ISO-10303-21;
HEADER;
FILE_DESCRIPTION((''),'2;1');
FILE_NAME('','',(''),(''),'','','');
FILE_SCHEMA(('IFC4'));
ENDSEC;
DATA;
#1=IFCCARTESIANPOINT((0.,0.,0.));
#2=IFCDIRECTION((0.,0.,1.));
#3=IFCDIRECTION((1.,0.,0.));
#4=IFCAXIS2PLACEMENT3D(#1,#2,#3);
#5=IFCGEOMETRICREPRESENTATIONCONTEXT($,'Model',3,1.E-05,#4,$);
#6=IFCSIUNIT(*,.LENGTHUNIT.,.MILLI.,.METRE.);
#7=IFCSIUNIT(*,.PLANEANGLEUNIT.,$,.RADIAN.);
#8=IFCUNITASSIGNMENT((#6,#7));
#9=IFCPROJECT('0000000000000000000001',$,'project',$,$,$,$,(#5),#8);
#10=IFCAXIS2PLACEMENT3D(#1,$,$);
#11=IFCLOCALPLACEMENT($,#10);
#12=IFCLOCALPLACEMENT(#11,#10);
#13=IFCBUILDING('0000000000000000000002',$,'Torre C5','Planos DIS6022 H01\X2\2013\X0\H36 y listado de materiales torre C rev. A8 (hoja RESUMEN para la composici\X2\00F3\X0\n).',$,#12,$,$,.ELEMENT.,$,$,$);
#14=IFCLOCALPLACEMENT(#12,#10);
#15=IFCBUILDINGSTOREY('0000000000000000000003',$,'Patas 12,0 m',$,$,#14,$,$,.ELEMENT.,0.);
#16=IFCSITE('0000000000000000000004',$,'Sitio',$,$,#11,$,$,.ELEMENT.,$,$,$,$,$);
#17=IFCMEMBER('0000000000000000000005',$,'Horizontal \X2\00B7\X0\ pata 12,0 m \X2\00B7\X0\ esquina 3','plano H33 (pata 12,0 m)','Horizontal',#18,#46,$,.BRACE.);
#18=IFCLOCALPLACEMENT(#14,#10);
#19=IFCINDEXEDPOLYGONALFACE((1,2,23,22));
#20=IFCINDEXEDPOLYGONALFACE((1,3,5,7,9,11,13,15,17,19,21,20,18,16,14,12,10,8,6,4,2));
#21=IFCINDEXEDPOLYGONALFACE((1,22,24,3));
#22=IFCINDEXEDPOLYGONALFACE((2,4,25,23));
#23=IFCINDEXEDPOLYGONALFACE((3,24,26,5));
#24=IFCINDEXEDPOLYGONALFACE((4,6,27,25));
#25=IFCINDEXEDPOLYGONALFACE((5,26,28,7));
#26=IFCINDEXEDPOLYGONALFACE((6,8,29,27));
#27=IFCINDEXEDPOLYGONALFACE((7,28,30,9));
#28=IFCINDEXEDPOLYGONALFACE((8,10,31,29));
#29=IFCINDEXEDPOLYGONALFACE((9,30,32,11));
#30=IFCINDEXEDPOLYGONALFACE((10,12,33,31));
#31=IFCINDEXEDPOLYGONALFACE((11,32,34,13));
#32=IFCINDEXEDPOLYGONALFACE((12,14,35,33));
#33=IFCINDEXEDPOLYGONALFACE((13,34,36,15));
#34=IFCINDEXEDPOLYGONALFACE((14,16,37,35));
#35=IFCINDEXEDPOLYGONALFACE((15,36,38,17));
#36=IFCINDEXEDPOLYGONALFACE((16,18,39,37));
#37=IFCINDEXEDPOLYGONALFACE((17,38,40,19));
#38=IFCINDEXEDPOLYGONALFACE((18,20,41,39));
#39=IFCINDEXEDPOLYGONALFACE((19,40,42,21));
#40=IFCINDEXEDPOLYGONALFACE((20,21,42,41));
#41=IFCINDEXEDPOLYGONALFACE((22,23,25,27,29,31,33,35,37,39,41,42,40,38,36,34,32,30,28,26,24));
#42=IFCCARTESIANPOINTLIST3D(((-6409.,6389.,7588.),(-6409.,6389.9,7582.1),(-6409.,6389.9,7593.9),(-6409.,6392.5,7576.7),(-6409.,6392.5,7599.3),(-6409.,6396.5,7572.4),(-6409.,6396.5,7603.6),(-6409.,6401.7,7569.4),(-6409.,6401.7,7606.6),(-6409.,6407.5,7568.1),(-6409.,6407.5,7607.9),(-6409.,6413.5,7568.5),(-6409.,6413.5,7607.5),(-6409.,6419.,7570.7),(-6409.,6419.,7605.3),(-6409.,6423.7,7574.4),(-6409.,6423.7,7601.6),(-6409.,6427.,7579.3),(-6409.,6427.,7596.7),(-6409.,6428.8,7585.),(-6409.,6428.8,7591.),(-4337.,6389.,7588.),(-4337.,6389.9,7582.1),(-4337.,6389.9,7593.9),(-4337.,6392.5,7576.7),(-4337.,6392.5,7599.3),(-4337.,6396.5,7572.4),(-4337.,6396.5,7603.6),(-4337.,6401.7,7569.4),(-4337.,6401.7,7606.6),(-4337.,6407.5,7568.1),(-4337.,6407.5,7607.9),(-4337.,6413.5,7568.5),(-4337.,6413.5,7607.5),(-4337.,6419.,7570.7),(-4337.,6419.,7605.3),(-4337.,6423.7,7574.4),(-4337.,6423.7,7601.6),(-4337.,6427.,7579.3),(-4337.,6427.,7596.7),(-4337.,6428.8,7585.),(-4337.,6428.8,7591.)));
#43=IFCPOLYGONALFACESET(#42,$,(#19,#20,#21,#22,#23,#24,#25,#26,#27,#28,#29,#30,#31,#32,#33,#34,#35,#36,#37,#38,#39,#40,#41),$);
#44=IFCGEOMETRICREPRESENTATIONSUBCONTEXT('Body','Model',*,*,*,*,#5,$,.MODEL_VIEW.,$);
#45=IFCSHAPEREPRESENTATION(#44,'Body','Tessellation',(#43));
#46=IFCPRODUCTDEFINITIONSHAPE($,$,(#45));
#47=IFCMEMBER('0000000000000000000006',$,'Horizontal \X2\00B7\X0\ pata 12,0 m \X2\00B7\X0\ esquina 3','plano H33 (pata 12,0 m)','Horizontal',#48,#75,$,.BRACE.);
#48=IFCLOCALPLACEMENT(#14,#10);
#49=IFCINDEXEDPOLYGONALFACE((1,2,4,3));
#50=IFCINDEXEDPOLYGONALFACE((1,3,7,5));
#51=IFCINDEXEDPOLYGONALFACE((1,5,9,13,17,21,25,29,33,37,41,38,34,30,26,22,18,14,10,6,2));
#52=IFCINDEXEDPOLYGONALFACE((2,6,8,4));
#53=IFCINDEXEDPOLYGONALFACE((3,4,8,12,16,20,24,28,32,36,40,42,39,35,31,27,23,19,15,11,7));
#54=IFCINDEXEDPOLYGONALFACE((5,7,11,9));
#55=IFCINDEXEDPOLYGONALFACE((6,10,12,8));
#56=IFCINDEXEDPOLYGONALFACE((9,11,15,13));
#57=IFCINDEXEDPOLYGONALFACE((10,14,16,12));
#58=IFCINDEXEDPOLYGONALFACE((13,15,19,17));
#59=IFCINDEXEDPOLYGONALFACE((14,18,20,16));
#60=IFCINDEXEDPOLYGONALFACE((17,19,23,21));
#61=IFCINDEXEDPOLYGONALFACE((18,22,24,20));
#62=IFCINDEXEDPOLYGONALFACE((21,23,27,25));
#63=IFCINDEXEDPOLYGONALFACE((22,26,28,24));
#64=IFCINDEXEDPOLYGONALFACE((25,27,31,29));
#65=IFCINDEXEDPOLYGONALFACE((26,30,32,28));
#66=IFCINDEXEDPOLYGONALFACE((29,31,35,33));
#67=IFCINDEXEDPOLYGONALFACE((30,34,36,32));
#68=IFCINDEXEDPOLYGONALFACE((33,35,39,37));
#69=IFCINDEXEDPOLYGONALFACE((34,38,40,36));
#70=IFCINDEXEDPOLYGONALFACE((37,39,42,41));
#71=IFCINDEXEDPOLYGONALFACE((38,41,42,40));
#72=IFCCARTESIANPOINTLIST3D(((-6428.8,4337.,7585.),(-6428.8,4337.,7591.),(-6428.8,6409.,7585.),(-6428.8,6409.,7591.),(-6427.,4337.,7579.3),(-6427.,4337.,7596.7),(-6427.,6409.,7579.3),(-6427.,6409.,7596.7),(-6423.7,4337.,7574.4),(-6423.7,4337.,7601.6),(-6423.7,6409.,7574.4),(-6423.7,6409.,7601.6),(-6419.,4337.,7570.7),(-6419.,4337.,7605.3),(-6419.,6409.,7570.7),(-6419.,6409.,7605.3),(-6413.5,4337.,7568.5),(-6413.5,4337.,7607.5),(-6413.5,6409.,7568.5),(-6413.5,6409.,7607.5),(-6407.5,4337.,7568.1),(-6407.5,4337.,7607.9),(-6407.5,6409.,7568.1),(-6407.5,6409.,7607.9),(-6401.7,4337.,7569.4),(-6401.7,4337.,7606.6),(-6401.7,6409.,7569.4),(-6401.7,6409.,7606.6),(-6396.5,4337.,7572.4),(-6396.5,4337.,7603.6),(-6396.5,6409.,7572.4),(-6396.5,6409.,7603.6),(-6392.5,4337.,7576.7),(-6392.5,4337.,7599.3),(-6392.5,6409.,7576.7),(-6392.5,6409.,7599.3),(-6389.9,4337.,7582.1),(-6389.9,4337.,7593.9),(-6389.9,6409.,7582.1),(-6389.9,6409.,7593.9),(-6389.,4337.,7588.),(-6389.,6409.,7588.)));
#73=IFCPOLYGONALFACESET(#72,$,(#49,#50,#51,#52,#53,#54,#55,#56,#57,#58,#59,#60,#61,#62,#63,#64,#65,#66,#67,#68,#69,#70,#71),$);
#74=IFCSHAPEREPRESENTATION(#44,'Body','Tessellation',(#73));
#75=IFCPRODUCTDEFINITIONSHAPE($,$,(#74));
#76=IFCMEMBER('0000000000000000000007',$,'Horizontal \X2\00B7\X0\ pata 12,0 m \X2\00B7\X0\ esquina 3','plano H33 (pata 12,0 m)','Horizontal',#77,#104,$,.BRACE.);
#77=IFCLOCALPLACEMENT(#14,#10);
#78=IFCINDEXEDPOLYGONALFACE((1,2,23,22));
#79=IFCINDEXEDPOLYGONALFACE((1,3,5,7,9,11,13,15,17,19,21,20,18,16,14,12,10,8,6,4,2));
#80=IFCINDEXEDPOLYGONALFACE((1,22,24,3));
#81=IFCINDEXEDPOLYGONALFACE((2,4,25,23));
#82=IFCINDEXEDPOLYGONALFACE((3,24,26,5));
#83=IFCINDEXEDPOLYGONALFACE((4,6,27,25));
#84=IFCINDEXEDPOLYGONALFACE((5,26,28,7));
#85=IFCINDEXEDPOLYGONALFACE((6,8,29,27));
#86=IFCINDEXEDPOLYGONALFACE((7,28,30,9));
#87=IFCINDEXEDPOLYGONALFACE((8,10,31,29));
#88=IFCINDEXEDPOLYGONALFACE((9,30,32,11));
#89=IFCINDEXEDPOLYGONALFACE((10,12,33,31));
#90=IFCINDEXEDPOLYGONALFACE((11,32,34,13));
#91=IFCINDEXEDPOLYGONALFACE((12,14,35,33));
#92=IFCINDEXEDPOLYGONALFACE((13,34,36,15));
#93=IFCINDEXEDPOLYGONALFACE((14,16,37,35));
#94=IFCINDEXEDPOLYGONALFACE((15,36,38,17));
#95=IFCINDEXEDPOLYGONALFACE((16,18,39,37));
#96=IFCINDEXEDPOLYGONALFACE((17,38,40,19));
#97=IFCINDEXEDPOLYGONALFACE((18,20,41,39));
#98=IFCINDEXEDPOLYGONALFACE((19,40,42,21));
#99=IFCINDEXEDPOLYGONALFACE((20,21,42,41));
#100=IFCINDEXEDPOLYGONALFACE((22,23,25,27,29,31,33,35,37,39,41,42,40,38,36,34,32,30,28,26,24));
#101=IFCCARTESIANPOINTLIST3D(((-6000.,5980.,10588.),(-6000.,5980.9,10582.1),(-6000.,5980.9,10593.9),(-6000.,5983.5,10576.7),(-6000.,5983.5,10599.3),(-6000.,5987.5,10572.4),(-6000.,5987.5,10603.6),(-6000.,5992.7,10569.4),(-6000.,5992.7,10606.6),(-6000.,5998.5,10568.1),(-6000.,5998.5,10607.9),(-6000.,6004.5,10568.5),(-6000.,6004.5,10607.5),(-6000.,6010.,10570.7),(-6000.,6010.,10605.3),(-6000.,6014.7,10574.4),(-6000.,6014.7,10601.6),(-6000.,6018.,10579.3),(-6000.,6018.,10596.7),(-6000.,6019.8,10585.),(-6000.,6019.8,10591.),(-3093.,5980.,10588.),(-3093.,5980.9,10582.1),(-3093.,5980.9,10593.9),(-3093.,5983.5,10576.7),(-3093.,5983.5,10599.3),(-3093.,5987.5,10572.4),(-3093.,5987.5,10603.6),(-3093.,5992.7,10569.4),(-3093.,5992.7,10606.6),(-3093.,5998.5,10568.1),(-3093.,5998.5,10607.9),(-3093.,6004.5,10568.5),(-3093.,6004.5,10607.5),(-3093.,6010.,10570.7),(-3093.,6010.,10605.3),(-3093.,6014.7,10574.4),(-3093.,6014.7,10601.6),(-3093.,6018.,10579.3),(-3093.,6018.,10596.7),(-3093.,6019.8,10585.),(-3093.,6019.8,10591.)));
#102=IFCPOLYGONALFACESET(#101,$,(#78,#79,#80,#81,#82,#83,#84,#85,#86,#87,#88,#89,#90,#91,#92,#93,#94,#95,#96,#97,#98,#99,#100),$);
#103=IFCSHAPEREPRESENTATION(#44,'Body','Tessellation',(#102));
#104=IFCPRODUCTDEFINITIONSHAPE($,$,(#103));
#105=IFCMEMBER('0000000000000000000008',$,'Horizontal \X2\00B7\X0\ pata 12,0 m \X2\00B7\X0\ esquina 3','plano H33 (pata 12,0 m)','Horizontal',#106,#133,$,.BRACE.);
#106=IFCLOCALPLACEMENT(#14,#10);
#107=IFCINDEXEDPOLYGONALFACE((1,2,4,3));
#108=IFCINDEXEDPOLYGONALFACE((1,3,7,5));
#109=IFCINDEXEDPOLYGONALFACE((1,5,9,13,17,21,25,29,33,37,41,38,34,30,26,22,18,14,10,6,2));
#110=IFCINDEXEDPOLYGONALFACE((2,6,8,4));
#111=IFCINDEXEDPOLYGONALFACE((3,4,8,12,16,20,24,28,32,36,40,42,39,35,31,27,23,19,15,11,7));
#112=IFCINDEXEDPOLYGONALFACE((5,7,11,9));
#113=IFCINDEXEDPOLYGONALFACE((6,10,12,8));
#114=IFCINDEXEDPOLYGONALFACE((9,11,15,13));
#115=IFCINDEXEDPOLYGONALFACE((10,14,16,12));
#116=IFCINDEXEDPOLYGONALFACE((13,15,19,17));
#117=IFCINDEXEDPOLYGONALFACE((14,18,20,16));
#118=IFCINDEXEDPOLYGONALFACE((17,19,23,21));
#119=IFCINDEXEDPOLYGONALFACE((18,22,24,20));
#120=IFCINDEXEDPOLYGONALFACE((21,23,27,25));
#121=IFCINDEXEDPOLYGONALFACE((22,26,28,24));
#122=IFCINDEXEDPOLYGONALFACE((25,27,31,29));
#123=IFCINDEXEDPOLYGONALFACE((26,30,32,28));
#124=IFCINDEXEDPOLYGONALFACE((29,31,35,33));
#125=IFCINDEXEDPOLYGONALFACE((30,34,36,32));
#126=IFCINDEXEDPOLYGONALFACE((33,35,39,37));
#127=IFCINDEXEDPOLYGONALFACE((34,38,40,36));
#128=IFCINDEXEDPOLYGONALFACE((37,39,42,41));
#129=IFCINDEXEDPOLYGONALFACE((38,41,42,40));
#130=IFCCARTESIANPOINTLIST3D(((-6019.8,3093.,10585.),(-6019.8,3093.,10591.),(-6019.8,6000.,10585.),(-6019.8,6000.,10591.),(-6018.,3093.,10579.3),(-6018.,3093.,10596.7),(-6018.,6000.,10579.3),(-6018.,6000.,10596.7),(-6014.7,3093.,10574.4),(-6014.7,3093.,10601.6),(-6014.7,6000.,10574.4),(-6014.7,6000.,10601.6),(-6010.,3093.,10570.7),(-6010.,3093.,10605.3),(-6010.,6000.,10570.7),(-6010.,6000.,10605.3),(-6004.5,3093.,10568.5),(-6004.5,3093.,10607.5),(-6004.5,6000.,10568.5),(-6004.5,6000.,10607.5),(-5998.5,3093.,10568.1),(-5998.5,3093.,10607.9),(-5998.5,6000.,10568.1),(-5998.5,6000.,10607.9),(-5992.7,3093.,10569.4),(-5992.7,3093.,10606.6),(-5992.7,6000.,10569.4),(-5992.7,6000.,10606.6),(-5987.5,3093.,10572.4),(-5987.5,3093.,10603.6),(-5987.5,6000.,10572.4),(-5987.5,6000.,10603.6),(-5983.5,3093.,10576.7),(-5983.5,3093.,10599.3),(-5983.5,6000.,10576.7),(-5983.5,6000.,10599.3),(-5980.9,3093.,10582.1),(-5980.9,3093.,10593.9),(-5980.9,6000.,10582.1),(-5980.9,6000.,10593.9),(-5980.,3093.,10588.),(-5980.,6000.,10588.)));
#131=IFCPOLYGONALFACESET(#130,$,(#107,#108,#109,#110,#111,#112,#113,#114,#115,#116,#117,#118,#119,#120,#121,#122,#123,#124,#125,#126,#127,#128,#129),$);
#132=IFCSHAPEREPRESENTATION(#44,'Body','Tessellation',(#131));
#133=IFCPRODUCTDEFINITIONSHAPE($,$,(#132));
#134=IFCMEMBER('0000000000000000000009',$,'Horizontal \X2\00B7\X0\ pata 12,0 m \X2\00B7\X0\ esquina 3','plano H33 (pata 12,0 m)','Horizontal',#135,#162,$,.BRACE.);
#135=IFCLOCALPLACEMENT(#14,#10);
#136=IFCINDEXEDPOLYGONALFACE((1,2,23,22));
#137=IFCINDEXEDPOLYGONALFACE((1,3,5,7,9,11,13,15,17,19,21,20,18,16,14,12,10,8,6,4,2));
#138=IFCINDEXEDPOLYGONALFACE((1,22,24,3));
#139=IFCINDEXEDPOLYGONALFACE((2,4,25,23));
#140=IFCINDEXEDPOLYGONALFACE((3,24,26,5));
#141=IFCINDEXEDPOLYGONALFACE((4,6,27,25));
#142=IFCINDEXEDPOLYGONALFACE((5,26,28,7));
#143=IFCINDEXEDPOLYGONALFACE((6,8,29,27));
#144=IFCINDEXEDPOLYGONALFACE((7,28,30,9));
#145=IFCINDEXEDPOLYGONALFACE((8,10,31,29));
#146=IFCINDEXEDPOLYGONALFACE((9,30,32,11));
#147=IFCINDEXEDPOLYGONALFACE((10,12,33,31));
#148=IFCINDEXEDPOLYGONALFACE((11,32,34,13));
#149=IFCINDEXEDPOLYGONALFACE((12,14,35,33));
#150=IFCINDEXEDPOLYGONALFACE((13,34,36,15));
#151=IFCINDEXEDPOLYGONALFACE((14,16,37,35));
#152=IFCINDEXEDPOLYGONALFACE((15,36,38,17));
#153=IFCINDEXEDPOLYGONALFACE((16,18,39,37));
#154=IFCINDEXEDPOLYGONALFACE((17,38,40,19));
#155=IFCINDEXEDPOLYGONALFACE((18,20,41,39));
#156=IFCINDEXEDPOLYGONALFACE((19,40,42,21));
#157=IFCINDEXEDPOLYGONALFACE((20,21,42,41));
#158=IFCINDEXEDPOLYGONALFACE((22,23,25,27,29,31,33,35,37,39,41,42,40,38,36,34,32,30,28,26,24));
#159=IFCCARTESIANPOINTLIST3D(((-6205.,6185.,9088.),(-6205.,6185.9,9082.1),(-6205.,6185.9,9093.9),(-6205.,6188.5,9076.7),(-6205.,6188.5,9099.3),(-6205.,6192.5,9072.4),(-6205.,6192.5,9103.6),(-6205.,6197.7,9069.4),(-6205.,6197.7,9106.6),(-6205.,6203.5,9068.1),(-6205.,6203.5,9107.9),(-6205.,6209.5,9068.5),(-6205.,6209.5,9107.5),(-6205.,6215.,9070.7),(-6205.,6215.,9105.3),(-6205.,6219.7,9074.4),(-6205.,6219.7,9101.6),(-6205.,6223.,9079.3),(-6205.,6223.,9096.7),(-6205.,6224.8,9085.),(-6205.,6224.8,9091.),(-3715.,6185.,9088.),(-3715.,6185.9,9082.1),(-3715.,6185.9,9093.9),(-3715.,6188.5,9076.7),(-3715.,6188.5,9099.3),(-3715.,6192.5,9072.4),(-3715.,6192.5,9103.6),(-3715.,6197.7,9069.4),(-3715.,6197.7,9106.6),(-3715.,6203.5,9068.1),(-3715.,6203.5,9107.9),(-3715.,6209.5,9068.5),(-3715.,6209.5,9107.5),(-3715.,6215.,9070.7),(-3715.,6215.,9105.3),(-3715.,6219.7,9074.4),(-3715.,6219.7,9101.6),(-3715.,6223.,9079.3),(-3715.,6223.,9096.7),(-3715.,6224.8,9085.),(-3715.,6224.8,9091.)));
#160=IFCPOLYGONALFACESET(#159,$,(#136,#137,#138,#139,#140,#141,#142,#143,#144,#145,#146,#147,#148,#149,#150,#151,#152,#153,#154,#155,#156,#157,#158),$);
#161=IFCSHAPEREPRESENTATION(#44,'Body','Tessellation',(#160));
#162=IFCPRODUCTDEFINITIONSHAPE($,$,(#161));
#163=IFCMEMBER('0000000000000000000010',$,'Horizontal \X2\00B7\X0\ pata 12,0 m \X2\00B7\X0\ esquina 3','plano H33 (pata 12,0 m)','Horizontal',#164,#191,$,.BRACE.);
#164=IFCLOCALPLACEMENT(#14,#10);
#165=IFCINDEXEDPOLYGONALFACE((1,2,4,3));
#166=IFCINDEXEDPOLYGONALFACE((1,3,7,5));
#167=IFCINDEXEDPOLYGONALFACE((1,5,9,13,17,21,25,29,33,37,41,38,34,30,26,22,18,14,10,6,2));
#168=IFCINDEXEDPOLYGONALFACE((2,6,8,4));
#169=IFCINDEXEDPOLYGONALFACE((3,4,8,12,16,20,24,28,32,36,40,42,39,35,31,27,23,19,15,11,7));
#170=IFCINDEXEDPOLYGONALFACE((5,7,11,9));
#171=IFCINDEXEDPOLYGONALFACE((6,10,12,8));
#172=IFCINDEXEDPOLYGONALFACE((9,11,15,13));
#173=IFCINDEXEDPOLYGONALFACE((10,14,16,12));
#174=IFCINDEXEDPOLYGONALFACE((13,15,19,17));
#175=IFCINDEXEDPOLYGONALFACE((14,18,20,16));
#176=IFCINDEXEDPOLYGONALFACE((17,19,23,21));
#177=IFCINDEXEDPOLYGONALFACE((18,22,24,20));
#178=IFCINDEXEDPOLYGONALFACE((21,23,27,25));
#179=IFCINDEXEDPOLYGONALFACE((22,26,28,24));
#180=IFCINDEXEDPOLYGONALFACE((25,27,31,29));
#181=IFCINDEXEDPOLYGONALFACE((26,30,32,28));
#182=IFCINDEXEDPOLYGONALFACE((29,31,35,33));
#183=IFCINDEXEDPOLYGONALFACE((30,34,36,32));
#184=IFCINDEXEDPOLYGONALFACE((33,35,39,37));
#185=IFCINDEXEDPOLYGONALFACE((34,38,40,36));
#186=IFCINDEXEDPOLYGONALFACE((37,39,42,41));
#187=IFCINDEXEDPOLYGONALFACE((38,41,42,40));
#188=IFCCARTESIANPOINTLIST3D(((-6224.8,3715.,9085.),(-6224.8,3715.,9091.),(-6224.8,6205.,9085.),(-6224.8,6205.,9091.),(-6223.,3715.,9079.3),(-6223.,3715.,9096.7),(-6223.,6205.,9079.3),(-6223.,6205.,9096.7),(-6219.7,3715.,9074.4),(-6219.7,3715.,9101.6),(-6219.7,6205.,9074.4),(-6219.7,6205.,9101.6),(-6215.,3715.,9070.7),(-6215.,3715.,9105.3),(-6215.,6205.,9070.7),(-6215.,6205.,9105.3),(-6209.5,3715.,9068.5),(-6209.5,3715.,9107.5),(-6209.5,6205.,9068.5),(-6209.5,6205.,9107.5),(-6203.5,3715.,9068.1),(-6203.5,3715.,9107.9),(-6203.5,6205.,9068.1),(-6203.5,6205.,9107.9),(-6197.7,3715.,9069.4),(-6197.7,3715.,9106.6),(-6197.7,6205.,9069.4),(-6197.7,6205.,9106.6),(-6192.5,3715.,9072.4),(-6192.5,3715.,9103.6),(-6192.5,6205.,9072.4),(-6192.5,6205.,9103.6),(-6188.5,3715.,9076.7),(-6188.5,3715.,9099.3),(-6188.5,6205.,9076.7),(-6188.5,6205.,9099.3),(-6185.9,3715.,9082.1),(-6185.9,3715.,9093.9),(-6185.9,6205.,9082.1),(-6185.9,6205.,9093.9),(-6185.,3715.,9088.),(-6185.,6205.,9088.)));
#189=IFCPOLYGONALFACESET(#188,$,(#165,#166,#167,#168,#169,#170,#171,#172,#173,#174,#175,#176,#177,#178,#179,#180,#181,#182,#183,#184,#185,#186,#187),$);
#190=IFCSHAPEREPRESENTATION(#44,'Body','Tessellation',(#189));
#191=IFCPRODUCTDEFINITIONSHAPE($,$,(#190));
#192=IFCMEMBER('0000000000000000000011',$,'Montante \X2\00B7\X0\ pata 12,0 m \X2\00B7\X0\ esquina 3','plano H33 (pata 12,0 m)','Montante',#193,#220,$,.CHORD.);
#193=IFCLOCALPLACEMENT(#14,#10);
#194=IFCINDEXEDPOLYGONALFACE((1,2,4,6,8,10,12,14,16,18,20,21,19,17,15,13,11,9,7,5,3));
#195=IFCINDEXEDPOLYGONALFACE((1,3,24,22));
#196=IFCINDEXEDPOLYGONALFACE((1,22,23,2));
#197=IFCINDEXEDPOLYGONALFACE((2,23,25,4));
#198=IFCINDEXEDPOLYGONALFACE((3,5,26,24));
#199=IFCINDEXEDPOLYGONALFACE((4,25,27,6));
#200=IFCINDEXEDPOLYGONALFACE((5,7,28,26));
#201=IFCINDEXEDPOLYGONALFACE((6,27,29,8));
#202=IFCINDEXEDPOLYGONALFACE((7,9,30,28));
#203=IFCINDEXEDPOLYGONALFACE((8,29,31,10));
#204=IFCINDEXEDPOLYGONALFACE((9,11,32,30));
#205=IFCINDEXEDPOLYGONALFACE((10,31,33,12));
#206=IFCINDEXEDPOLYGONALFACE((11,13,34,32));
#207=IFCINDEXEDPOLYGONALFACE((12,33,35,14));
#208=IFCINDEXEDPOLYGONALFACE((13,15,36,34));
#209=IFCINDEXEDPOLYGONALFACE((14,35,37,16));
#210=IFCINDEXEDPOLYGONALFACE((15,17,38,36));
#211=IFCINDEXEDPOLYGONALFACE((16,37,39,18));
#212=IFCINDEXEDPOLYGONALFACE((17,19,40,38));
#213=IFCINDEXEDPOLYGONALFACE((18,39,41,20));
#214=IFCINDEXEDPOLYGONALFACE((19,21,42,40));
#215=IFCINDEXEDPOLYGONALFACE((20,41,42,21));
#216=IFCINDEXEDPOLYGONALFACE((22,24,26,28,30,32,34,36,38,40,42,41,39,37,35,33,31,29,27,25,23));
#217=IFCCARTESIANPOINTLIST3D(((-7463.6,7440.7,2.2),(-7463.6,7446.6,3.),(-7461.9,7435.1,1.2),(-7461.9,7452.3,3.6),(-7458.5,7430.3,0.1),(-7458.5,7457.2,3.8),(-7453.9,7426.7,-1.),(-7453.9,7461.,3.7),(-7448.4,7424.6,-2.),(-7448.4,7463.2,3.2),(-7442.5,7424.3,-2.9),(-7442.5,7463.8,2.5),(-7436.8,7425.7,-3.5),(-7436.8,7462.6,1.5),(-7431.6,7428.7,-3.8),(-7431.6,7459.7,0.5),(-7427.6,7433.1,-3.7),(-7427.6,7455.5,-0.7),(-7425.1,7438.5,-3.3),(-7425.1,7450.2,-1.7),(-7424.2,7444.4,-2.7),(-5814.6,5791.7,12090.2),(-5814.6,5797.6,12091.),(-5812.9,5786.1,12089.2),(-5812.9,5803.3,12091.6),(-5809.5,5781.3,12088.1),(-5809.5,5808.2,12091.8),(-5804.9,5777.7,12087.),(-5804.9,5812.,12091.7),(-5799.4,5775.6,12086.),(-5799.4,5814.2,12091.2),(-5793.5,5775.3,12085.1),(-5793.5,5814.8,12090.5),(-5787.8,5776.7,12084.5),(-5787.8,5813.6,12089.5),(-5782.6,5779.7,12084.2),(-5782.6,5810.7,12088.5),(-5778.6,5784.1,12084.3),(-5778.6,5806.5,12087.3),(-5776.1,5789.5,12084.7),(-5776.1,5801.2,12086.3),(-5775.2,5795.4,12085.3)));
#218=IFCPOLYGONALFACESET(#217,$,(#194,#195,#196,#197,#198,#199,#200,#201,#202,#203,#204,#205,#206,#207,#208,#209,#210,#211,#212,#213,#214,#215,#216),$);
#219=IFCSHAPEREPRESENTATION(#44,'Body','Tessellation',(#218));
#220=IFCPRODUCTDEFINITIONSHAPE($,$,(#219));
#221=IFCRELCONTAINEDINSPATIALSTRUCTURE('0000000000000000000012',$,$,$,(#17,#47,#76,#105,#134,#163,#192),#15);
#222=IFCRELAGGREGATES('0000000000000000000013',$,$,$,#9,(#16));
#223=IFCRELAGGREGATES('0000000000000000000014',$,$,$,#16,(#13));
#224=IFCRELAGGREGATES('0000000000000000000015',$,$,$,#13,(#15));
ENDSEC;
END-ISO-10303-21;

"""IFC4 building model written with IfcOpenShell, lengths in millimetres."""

from ifc_helpers import new_model, si_unit, frame, origin, origin_with_axes, place, context, subcontext, project, spatial, circle, extrude, element, save


model = new_model("IFC4")

# Units and contexts
model_context = context("Model", 3, precision=1e-05, world=origin_with_axes())
body_context = subcontext(model_context, "Body", "Model", "MODEL_VIEW")
ifc_project = project(units=[si_unit("LENGTHUNIT", "METRE", prefix="MILLI"), si_unit("PLANEANGLEUNIT", "RADIAN")], contexts=[model_context])

# Site, building, storey
site_placement = place(None, origin())
site = spatial("IfcSite", under=ifc_project, at=site_placement, Name="Sitio", CompositionType="ELEMENT")
building_placement = place(site_placement, origin())
building = spatial("IfcBuilding", under=site, at=building_placement, Name="Torre C5", Description="Planos DIS6022 H01–H36 y listado de materiales torre C rev. A8 (hoja RESUMEN para la composición).", CompositionType="ELEMENT")
storey_placement = place(building_placement, origin())
storey = spatial("IfcBuildingStorey", under=building, at=storey_placement, Name="Patas 12,0 m", CompositionType="ELEMENT", Elevation=0.0)

# Members
for number, where, z_axis, x_axis, name in (
    (1, (-4337.0, 6409.0, 7588.0), (-1.0, 0.0, 0.0), (0.0, -1.0, 0.0), "Horizontal · pata 12,0 m · esquina 3"),
    (2, (-6409.0, 4337.0, 7588.0), (0.0, 1.0, 0.0), (1.0, 0.0, 0.0), "Horizontal · pata 12,0 m · esquina 3"),
):
    element("IfcMember", number, at=place(storey_placement, frame(where, z_axis=z_axis, x_axis=x_axis)), inside=storey, Name=name, Description="plano H33 (pata 12,0 m)", ObjectType="Horizontal", PredefinedType="BRACE", context=body_context, shape_type="SweptSolid", body=[
        extrude(circle(Radius=20.0), None, (0.0, 0.0, 1.0), 2072.0),
    ])
for number, where, z_axis, x_axis, name in (
    (3, (-6000.0, 6000.0, 10588.0), (1.0, 0.0, 0.0), (0.0, -1.0, 0.0), "Horizontal · pata 12,0 m · esquina 3"),
    (4, (-6000.0, 6000.0, 10588.0), (0.0, -1.0, 0.0), (1.0, 0.0, 0.0), "Horizontal · pata 12,0 m · esquina 3"),
):
    element("IfcMember", number, at=place(storey_placement, frame(where, z_axis=z_axis, x_axis=x_axis)), inside=storey, Name=name, Description="plano H33 (pata 12,0 m)", ObjectType="Horizontal", PredefinedType="BRACE", context=body_context, shape_type="SweptSolid", body=[
        extrude(circle(Radius=20.0), None, (0.0, 0.0, 1.0), 2907.0),
    ])
for number, where, z_axis, x_axis, name in (
    (5, (-6205.0, 6205.0, 9088.0), (1.0, 0.0, 0.0), (0.0, -1.0, 0.0), "Horizontal · pata 12,0 m · esquina 3"),
    (6, (-6205.0, 6205.0, 9088.0), (0.0, -1.0, 0.0), (1.0, 0.0, 0.0), "Horizontal · pata 12,0 m · esquina 3"),
):
    element("IfcMember", number, at=place(storey_placement, frame(where, z_axis=z_axis, x_axis=x_axis)), inside=storey, Name=name, Description="plano H33 (pata 12,0 m)", ObjectType="Horizontal", PredefinedType="BRACE", context=body_context, shape_type="SweptSolid", body=[
        extrude(circle(Radius=20.0), None, (0.0, 0.0, 1.0), 2490.0),
    ])
member_1_placement = place(storey_placement, frame((-5795.0, 5795.0, 12088.0), z_axis=(-0.133946, 0.133946, -0.981894), x_axis=(0.990989, 0.018105, -0.132717)))
element("IfcMember", 7, at=member_1_placement, inside=storey, Name="Montante · pata 12,0 m · esquina 3", Description="plano H33 (pata 12,0 m)", ObjectType="Montante", PredefinedType="CHORD", context=body_context, shape_type="SweptSolid", body=[
    extrude(circle(Radius=20.0), None, (0.0, 0.0, 1.0), 12310.9),
])

save(model, "model.ifc")
